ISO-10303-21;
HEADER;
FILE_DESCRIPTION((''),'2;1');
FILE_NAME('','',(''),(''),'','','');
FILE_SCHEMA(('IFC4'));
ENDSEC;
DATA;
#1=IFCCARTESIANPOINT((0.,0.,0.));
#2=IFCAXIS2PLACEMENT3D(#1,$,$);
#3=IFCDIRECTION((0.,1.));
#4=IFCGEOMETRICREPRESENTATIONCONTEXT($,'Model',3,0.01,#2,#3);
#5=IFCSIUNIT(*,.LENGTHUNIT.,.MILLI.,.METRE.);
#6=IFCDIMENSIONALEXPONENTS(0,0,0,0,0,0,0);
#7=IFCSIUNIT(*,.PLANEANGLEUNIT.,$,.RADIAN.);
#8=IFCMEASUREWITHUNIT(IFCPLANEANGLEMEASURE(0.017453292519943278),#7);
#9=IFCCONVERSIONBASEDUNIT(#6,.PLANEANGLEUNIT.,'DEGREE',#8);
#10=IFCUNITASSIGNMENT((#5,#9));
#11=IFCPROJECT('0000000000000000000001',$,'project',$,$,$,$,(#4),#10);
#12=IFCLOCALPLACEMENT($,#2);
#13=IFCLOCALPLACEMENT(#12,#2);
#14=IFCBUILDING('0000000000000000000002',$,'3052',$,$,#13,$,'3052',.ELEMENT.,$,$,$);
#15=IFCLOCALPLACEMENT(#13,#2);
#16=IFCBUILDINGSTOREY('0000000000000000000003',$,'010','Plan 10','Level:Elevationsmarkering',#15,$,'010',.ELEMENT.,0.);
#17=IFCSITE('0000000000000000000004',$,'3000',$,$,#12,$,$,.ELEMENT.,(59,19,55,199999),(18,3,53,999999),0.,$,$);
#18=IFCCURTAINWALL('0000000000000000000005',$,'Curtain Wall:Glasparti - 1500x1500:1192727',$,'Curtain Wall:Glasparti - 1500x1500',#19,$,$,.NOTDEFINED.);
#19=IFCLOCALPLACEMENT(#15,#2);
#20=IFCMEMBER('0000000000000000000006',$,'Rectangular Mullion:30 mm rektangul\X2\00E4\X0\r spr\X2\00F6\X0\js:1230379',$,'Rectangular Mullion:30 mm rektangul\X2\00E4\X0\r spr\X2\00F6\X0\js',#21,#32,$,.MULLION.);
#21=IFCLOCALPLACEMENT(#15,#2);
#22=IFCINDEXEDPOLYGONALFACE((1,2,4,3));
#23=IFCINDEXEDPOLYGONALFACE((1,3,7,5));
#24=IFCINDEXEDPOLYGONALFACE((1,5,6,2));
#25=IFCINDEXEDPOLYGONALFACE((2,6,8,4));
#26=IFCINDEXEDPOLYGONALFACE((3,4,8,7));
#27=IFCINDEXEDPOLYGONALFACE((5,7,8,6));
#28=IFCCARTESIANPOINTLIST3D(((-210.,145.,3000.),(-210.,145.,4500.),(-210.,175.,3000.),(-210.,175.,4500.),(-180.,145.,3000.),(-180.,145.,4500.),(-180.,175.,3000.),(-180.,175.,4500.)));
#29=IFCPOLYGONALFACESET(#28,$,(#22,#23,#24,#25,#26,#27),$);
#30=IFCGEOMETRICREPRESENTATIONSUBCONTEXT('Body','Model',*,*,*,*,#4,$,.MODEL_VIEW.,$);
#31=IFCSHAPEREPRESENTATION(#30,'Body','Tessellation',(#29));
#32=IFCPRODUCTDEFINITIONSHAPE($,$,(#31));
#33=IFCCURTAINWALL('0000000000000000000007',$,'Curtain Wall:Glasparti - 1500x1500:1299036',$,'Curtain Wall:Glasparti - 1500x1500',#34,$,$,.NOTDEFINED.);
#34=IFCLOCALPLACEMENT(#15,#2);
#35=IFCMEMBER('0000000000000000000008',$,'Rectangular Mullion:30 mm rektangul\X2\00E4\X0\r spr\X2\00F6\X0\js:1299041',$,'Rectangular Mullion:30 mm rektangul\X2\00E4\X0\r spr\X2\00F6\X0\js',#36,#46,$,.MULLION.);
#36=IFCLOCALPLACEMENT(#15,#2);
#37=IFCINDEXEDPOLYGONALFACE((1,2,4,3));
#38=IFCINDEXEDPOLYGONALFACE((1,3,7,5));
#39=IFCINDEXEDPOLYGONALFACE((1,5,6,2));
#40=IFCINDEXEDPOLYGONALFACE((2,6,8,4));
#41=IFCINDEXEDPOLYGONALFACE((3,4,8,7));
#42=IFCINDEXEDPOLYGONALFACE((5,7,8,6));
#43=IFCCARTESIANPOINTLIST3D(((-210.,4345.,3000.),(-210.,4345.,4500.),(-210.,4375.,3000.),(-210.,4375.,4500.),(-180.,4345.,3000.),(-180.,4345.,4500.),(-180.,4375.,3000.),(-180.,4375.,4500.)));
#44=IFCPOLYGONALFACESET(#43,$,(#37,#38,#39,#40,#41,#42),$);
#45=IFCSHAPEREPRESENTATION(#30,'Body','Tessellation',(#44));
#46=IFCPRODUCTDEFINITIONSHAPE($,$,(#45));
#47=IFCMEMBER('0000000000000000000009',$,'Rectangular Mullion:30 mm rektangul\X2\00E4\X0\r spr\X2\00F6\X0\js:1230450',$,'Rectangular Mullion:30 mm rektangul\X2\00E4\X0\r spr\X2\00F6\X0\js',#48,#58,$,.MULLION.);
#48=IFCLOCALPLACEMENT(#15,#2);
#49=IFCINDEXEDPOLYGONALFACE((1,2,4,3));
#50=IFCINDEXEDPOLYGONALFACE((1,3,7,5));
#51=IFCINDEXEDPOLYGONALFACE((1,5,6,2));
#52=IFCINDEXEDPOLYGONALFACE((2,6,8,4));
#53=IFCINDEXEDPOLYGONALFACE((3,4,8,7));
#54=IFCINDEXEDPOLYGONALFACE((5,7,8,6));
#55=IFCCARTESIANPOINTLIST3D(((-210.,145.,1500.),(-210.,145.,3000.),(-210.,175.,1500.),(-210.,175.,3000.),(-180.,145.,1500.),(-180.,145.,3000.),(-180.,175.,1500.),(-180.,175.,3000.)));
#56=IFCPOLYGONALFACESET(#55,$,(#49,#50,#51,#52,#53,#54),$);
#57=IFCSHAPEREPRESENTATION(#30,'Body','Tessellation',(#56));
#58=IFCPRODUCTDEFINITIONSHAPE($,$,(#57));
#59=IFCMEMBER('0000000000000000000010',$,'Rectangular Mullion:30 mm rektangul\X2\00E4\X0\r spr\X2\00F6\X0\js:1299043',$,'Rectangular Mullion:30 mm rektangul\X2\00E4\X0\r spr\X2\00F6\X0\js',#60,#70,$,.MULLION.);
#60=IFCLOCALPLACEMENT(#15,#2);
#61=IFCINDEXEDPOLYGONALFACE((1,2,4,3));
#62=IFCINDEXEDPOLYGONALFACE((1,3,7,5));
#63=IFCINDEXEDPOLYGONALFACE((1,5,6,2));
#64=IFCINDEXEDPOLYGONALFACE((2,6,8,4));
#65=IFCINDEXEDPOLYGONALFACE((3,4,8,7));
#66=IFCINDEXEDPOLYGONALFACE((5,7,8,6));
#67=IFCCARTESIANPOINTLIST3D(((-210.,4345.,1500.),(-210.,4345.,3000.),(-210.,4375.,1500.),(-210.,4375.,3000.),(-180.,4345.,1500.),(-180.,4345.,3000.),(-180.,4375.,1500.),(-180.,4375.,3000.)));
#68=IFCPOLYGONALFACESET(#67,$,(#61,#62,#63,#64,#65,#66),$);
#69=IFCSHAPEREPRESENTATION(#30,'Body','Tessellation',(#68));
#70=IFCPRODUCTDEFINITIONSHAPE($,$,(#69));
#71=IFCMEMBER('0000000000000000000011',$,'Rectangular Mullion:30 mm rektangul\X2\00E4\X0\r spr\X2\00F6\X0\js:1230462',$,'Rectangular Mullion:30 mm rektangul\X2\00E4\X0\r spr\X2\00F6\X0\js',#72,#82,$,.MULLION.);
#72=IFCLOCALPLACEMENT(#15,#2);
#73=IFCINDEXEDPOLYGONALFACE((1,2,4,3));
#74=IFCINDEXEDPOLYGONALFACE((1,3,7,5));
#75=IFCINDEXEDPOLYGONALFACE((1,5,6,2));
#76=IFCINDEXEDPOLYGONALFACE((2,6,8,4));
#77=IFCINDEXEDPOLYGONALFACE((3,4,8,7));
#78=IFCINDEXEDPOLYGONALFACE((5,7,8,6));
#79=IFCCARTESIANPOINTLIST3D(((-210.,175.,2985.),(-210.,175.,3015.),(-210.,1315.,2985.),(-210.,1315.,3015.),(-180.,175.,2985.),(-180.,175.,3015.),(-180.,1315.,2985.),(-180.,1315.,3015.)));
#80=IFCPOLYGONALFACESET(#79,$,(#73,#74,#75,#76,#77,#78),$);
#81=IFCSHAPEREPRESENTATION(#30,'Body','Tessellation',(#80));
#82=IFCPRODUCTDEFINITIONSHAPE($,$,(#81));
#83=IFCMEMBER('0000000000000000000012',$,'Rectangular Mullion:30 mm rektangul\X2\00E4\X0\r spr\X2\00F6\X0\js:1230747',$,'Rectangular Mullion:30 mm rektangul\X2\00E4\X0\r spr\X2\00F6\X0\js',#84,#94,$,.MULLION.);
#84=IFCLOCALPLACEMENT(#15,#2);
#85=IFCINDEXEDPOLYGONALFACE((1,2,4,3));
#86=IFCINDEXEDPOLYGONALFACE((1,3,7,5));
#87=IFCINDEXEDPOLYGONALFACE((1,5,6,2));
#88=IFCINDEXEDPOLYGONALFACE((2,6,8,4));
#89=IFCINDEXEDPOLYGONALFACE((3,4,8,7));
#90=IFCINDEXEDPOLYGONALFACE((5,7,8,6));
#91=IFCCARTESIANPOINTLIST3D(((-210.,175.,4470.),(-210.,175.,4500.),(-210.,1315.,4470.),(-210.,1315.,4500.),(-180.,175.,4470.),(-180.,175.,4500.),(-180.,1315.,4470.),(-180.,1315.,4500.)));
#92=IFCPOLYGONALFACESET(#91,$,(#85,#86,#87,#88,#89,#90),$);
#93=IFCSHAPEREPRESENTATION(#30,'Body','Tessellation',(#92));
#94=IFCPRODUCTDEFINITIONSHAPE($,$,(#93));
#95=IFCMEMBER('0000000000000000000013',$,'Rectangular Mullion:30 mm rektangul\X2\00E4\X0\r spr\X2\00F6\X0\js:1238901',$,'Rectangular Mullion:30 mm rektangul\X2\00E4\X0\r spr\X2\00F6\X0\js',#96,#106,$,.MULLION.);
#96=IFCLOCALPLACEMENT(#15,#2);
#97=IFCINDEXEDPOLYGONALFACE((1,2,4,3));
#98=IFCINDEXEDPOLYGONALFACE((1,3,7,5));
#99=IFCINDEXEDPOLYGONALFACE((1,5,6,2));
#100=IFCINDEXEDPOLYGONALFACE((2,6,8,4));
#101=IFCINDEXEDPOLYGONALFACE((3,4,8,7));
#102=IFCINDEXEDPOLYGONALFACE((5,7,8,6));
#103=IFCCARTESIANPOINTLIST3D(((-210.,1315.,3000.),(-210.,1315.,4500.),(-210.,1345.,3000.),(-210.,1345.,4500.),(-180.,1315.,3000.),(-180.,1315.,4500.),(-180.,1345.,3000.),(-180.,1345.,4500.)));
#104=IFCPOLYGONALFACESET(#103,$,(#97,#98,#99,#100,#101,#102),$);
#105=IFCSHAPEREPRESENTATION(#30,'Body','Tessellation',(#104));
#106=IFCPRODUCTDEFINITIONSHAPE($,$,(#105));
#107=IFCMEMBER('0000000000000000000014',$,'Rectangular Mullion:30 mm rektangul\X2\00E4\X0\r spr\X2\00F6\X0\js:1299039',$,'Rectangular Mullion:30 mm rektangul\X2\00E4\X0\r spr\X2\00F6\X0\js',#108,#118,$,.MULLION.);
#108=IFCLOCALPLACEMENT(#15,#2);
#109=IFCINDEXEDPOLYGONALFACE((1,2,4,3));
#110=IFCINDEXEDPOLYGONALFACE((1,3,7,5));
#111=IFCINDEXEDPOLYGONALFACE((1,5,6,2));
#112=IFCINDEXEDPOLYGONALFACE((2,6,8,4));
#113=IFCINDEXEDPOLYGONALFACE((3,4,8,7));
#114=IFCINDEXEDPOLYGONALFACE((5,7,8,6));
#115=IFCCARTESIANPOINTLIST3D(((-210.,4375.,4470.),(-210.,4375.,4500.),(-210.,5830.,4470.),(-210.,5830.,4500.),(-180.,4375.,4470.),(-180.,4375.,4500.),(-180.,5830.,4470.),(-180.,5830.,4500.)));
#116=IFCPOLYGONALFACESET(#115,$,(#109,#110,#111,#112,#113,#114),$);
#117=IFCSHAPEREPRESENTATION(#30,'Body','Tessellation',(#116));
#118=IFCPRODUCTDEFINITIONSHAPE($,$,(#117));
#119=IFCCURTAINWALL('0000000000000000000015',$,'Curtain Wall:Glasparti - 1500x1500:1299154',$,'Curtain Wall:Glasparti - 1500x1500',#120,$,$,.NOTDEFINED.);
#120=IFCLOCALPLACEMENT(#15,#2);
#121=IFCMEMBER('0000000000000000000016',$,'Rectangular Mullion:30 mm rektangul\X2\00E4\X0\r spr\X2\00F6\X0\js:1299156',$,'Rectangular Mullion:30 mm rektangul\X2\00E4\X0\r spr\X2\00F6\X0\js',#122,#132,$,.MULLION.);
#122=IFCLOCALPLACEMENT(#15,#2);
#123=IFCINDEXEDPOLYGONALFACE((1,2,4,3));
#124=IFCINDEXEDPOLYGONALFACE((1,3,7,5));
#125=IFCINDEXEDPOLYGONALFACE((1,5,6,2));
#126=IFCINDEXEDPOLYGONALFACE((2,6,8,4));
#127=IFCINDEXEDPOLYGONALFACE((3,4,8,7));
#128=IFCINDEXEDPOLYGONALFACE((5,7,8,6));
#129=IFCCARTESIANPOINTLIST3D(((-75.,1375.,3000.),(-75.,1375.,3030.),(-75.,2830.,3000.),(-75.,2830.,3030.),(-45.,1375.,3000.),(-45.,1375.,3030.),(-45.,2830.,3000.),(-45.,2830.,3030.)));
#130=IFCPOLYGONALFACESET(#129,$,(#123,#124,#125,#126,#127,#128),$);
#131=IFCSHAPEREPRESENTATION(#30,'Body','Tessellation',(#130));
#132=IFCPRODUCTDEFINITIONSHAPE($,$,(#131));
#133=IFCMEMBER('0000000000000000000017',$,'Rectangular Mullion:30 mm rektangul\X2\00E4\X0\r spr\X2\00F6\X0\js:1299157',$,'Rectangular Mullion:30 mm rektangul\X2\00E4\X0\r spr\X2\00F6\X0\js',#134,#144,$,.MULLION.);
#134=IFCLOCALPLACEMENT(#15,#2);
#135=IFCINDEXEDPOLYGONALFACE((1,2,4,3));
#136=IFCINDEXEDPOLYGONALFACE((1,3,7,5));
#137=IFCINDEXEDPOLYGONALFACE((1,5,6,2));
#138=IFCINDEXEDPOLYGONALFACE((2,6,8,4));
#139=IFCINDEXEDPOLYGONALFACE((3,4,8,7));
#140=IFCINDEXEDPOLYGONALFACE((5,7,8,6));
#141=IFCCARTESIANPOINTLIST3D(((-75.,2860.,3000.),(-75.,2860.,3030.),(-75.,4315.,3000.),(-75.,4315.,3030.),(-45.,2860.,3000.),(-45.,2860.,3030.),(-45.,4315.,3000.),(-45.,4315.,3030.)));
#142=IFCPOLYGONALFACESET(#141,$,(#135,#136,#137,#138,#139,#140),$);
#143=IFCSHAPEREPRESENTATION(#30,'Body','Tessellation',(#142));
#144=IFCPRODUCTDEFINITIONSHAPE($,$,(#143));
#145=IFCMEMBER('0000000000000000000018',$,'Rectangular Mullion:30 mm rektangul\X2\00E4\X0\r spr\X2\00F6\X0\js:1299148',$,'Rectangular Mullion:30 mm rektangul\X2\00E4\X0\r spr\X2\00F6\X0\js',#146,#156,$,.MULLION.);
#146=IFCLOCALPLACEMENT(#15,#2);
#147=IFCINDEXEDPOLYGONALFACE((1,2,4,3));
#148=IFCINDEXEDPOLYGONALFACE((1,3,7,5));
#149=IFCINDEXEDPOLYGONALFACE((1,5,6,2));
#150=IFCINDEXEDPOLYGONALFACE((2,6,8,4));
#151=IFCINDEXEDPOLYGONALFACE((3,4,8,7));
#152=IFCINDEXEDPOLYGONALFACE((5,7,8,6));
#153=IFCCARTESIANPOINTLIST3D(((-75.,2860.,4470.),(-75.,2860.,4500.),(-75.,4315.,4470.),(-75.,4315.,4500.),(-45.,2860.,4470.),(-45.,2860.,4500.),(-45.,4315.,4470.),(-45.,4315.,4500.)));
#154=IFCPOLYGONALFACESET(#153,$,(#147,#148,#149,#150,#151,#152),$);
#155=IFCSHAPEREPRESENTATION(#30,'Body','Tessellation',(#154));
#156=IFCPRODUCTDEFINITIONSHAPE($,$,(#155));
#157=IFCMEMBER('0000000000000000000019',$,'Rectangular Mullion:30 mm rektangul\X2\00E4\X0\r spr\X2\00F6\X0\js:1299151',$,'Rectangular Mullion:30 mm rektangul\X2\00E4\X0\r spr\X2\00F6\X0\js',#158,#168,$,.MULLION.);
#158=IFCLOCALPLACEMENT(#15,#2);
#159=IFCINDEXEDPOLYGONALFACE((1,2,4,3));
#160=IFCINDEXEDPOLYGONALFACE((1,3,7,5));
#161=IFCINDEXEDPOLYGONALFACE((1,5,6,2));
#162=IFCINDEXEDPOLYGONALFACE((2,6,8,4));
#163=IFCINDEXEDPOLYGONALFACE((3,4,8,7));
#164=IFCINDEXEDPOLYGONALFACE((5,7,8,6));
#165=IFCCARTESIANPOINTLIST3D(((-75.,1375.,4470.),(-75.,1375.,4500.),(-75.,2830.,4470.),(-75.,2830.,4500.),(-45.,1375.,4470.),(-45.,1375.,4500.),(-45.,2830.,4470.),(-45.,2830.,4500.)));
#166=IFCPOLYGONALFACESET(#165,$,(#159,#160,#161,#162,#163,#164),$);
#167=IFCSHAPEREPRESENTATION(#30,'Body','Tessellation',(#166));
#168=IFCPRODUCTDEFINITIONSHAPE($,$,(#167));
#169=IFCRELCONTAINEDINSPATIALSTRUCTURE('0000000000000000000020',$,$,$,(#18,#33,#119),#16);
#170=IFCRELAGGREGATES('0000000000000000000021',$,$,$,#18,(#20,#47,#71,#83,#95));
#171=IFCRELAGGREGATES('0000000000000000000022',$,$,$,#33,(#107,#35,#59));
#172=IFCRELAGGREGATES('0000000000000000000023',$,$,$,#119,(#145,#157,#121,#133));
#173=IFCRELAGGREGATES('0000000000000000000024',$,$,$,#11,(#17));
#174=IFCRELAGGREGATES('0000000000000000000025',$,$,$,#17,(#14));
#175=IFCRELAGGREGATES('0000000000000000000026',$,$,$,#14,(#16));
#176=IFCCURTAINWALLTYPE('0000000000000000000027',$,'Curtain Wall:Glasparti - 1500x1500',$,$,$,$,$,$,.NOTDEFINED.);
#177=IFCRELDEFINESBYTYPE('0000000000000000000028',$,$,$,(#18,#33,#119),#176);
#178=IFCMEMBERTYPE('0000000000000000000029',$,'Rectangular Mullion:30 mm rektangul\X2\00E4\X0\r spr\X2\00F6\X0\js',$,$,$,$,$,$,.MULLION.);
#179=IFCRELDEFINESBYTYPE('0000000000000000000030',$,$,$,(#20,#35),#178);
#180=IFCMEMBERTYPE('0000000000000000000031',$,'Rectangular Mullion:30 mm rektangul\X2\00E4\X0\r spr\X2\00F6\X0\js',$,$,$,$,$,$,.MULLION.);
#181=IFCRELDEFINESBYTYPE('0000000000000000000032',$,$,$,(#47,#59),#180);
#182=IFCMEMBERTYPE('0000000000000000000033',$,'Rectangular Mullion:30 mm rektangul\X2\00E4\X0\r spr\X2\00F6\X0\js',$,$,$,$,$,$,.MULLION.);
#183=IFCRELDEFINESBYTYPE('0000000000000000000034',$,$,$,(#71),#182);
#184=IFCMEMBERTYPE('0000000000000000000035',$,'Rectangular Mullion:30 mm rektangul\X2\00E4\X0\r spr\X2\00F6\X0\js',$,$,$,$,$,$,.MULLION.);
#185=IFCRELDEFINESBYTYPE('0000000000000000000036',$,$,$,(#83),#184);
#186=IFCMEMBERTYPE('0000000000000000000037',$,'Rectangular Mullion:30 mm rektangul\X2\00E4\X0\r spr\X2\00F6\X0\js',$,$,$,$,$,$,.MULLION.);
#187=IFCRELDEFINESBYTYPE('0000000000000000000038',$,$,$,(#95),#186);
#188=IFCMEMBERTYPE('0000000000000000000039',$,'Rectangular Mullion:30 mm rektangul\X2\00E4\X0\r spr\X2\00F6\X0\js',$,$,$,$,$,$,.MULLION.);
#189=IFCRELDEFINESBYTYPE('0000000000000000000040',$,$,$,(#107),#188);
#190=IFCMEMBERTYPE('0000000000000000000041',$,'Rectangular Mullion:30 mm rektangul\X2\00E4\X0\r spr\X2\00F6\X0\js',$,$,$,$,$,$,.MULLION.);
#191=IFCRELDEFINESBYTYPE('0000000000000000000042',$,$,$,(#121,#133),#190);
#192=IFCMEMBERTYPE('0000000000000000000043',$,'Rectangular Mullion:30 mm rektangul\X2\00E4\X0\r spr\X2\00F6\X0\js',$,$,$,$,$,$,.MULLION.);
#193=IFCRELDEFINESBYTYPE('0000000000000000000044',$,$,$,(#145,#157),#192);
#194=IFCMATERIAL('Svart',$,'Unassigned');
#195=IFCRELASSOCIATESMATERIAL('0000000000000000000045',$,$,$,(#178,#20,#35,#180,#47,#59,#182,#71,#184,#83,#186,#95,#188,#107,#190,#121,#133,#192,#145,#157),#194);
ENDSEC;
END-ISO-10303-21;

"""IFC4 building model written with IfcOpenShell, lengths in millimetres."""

from ifc_helpers import new_model, entity, si_unit, converted_unit, direction, frame, origin, place, context, subcontext, project, spatial, indexed_curve, outline, extrude, source, transform, mapped, material, type_object, type_shapes, element, aggregate, save


model = new_model("IFC4")

# Units and contexts
model_context = context("Model", 3, precision=0.01, world=origin(), true_north=direction((0.0, 1.0)))
body_context = subcontext(model_context, "Body", "Model", "MODEL_VIEW")
ifc_project = project(units=[si_unit("LENGTHUNIT", "METRE", prefix="MILLI"), converted_unit("PLANEANGLEUNIT", "DEGREE", entity("IfcPlaneAngleMeasure", 0.017453292519943278), si_unit("PLANEANGLEUNIT", "RADIAN"), dimensions=[0, 0, 0, 0, 0, 0, 0])], contexts=[model_context])

# Site, building, storey
site_placement = place(None, origin())
site = spatial("IfcSite", under=ifc_project, at=site_placement, Name="3000", CompositionType="ELEMENT", RefLatitude=(59, 19, 55, 199999), RefLongitude=(18, 3, 53, 999999), RefElevation=0.0)
building_placement = place(site_placement, origin())
building = spatial("IfcBuilding", under=site, at=building_placement, Name="3052", LongName="3052", CompositionType="ELEMENT")
storey_placement = place(building_placement, origin())
storey = spatial("IfcBuildingStorey", under=building, at=storey_placement, Name="010", Description="Plan 10", ObjectType="Level:Elevationsmarkering", LongName="010", CompositionType="ELEMENT", Elevation=0.0)

# Curtain walls, members
curtain_wall_type = type_object("IfcCurtainWallType", Name="Curtain Wall:Glasparti - 1500x1500", PredefinedType="NOTDEFINED")
curtain_wall_1_placement = place(storey_placement, origin())
curtain_wall_1 = element("IfcCurtainWall", 1, at=curtain_wall_1_placement, inside=storey, type_object=curtain_wall_type, Name="Curtain Wall:Glasparti - 1500x1500:1192727", ObjectType="Curtain Wall:Glasparti - 1500x1500", PredefinedType="NOTDEFINED")
ifc_material_1 = material(Name="Svart", Category="Unassigned")
member_type_1 = type_object("IfcMemberType", Name="Rectangular Mullion:30 mm rektangulär spröjs", PredefinedType="MULLION", material=ifc_material_1)
shared_shape_1 = source(origin(), body_context, "Body", "SweptSolid", [
    extrude(outline(indexed_curve([(-15.0, -15.0), (15.0, -15.0), (15.0, 15.0), (-15.0, 15.0), (-15.0, -15.0)], self_intersect=False)), frame((-15.0, 0.0, -1500.0), z_axis=(0.0, 0.0, 1.0), x_axis=(-1.0, 0.0, 0.0)), (0.0, 0.0, 1.0), 1500.0),
])
type_shapes(member_type_1, [shared_shape_1])
member_1_placement = place(curtain_wall_1_placement, frame((-195.0, 145.0, 4500.0), z_axis=(0.0, 0.0, 1.0), x_axis=(0.0, -1.0, 0.0)))
member_1 = element("IfcMember", 2, at=member_1_placement, type_object=member_type_1, material=ifc_material_1, Name="Rectangular Mullion:30 mm rektangulär spröjs:1230379", ObjectType="Rectangular Mullion:30 mm rektangulär spröjs", PredefinedType="MULLION", context=body_context, shape_type="MappedRepresentation", body=[
    mapped(shared_shape_1, transform((0.0, 0.0, 0.0), scale=1.0)),
])
curtain_wall_2_placement = place(storey_placement, origin())
curtain_wall_2 = element("IfcCurtainWall", 3, at=curtain_wall_2_placement, inside=storey, type_object=curtain_wall_type, Name="Curtain Wall:Glasparti - 1500x1500:1299036", ObjectType="Curtain Wall:Glasparti - 1500x1500", PredefinedType="NOTDEFINED")
member_2_placement = place(curtain_wall_2_placement, frame((-195.0, 4345.0, 4500.0), z_axis=(0.0, 0.0, 1.0), x_axis=(0.0, -1.0, 0.0)))
member_2 = element("IfcMember", 4, at=member_2_placement, type_object=member_type_1, material=ifc_material_1, Name="Rectangular Mullion:30 mm rektangulär spröjs:1299041", ObjectType="Rectangular Mullion:30 mm rektangulär spröjs", PredefinedType="MULLION", context=body_context, shape_type="MappedRepresentation", body=[
    mapped(shared_shape_1, transform((0.0, 0.0, 0.0), scale=1.0)),
])

# Members
member_type_2 = type_object("IfcMemberType", Name="Rectangular Mullion:30 mm rektangulär spröjs", PredefinedType="MULLION", material=ifc_material_1)
shared_shape_2 = source(origin(), body_context, "Body", "SweptSolid", [
    extrude(outline(indexed_curve([(-15.0, -15.0), (15.0, -15.0), (15.0, 15.0), (-15.0, 15.0), (-15.0, -15.0)], self_intersect=False)), frame((-15.0, 0.0, -1500.0), z_axis=(0.0, 0.0, 1.0), x_axis=(-1.0, 0.0, 0.0)), (0.0, 0.0, 1.0), 1500.0),
])
type_shapes(member_type_2, [shared_shape_2])
member_3_placement = place(curtain_wall_1_placement, frame((-195.0, 145.0, 3000.0), z_axis=(0.0, 0.0, 1.0), x_axis=(0.0, -1.0, 0.0)))
member_3 = element("IfcMember", 5, at=member_3_placement, type_object=member_type_2, material=ifc_material_1, Name="Rectangular Mullion:30 mm rektangulär spröjs:1230450", ObjectType="Rectangular Mullion:30 mm rektangulär spröjs", PredefinedType="MULLION", context=body_context, shape_type="MappedRepresentation", body=[
    mapped(shared_shape_2, transform((0.0, 0.0, 0.0), scale=1.0)),
])
member_4_placement = place(curtain_wall_2_placement, frame((-195.0, 4345.0, 3000.0), z_axis=(0.0, 0.0, 1.0), x_axis=(0.0, -1.0, 0.0)))
member_4 = element("IfcMember", 6, at=member_4_placement, type_object=member_type_2, material=ifc_material_1, Name="Rectangular Mullion:30 mm rektangulär spröjs:1299043", ObjectType="Rectangular Mullion:30 mm rektangulär spröjs", PredefinedType="MULLION", context=body_context, shape_type="MappedRepresentation", body=[
    mapped(shared_shape_2, transform((0.0, 0.0, 0.0), scale=1.0)),
])
member_type_3 = type_object("IfcMemberType", Name="Rectangular Mullion:30 mm rektangulär spröjs", PredefinedType="MULLION", material=ifc_material_1)
shared_shape_3 = source(origin(), body_context, "Body", "SweptSolid", [
    extrude(outline(indexed_curve([(-15.0, -15.0), (15.0, -15.0), (15.0, 15.0), (-15.0, 15.0), (-15.0, -15.0)], self_intersect=False)), frame((0.0, 0.0, -1140.0), z_axis=(0.0, 0.0, 1.0), x_axis=(-1.0, 0.0, 0.0)), (0.0, 0.0, 1.0), 1140.0),
])
type_shapes(member_type_3, [shared_shape_3])
member_5_placement = place(curtain_wall_1_placement, frame((-195.0, 1315.0, 3000.0), z_axis=(0.0, 1.0, 0.0), x_axis=(0.0, 0.0, 1.0)))
member_5 = element("IfcMember", 7, at=member_5_placement, type_object=member_type_3, material=ifc_material_1, Name="Rectangular Mullion:30 mm rektangulär spröjs:1230462", ObjectType="Rectangular Mullion:30 mm rektangulär spröjs", PredefinedType="MULLION", context=body_context, shape_type="MappedRepresentation", body=[
    mapped(shared_shape_3, transform((0.0, 0.0, 0.0), scale=1.0)),
])
member_type_4 = type_object("IfcMemberType", Name="Rectangular Mullion:30 mm rektangulär spröjs", PredefinedType="MULLION", material=ifc_material_1)
shared_shape_4 = source(origin(), body_context, "Body", "SweptSolid", [
    extrude(outline(indexed_curve([(-15.0, -15.0), (15.0, -15.0), (15.0, 15.0), (-15.0, 15.0), (-15.0, -15.0)], self_intersect=False)), frame((-15.0, 0.0, -1140.0), z_axis=(0.0, 0.0, 1.0), x_axis=(-1.0, 0.0, 0.0)), (0.0, 0.0, 1.0), 1140.0),
])
type_shapes(member_type_4, [shared_shape_4])
member_6_placement = place(curtain_wall_1_placement, frame((-195.0, 1315.0, 4500.0), z_axis=(0.0, 1.0, 0.0), x_axis=(0.0, 0.0, 1.0)))
member_6 = element("IfcMember", 8, at=member_6_placement, type_object=member_type_4, material=ifc_material_1, Name="Rectangular Mullion:30 mm rektangulär spröjs:1230747", ObjectType="Rectangular Mullion:30 mm rektangulär spröjs", PredefinedType="MULLION", context=body_context, shape_type="MappedRepresentation", body=[
    mapped(shared_shape_4, transform((0.0, 0.0, 0.0), scale=1.0)),
])
member_type_5 = type_object("IfcMemberType", Name="Rectangular Mullion:30 mm rektangulär spröjs", PredefinedType="MULLION", material=ifc_material_1)
shared_shape_5 = source(origin(), body_context, "Body", "SweptSolid", [
    extrude(outline(indexed_curve([(-15.0, -15.0), (15.0, -15.0), (15.0, 15.0), (-15.0, 15.0), (-15.0, -15.0)], self_intersect=False)), frame((-15.0, 0.0, -1500.0), z_axis=(0.0, 0.0, 1.0), x_axis=(-1.0, 0.0, 0.0)), (0.0, 0.0, 1.0), 1500.0),
])
type_shapes(member_type_5, [shared_shape_5])
member_7_placement = place(curtain_wall_1_placement, frame((-195.0, 1345.0, 3000.0), z_axis=(0.0, 0.0, -1.0), x_axis=(0.0, 1.0, 0.0)))
member_7 = element("IfcMember", 9, at=member_7_placement, type_object=member_type_5, material=ifc_material_1, Name="Rectangular Mullion:30 mm rektangulär spröjs:1238901", ObjectType="Rectangular Mullion:30 mm rektangulär spröjs", PredefinedType="MULLION", context=body_context, shape_type="MappedRepresentation", body=[
    mapped(shared_shape_5, transform((0.0, 0.0, 0.0), scale=1.0)),
])
member_type_6 = type_object("IfcMemberType", Name="Rectangular Mullion:30 mm rektangulär spröjs", PredefinedType="MULLION", material=ifc_material_1)
shared_shape_6 = source(origin(), body_context, "Body", "SweptSolid", [
    extrude(outline(indexed_curve([(-15.0, -15.0), (15.0, -15.0), (15.0, 15.0), (-15.0, 15.0), (-15.0, -15.0)], self_intersect=False)), frame((-15.0, 0.0, -1455.0), z_axis=(0.0, 0.0, 1.0), x_axis=(-1.0, 0.0, 0.0)), (0.0, 0.0, 1.0), 1455.0),
])
type_shapes(member_type_6, [shared_shape_6])
member_8_placement = place(curtain_wall_2_placement, frame((-195.0, 5830.0, 4500.0), z_axis=(0.0, 1.0, 0.0), x_axis=(0.0, 0.0, 1.0)))
member_8 = element("IfcMember", 10, at=member_8_placement, type_object=member_type_6, material=ifc_material_1, Name="Rectangular Mullion:30 mm rektangulär spröjs:1299039", ObjectType="Rectangular Mullion:30 mm rektangulär spröjs", PredefinedType="MULLION", context=body_context, shape_type="MappedRepresentation", body=[
    mapped(shared_shape_6, transform((0.0, 0.0, 0.0), scale=1.0)),
])

# Curtain wall, members
curtain_wall_3_placement = place(storey_placement, origin())
curtain_wall_3 = element("IfcCurtainWall", 11, at=curtain_wall_3_placement, inside=storey, type_object=curtain_wall_type, Name="Curtain Wall:Glasparti - 1500x1500:1299154", ObjectType="Curtain Wall:Glasparti - 1500x1500", PredefinedType="NOTDEFINED")
member_type_7 = type_object("IfcMemberType", Name="Rectangular Mullion:30 mm rektangulär spröjs", PredefinedType="MULLION", material=ifc_material_1)
shared_shape_7 = source(origin(), body_context, "Body", "SweptSolid", [
    extrude(outline(indexed_curve([(-15.0, -15.0), (15.0, -15.0), (15.0, 15.0), (-15.0, 15.0), (-15.0, -15.0)], self_intersect=False)), frame((-15.0, 0.0, -1455.0), z_axis=(0.0, 0.0, 1.0), x_axis=(-1.0, 0.0, 0.0)), (0.0, 0.0, 1.0), 1455.0),
])
type_shapes(member_type_7, [shared_shape_7])
member_9_placement = place(curtain_wall_3_placement, frame((-60.0, 1375.0, 3000.0), z_axis=(0.0, -1.0, 0.0), x_axis=(0.0, 0.0, -1.0)))
member_9 = element("IfcMember", 12, at=member_9_placement, type_object=member_type_7, material=ifc_material_1, Name="Rectangular Mullion:30 mm rektangulär spröjs:1299156", ObjectType="Rectangular Mullion:30 mm rektangulär spröjs", PredefinedType="MULLION", context=body_context, shape_type="MappedRepresentation", body=[
    mapped(shared_shape_7, transform((0.0, 0.0, 0.0), scale=1.0)),
])
member_10_placement = place(curtain_wall_3_placement, frame((-60.0, 2860.0, 3000.0), z_axis=(0.0, -1.0, 0.0), x_axis=(0.0, 0.0, -1.0)))
member_10 = element("IfcMember", 13, at=member_10_placement, type_object=member_type_7, material=ifc_material_1, Name="Rectangular Mullion:30 mm rektangulär spröjs:1299157", ObjectType="Rectangular Mullion:30 mm rektangulär spröjs", PredefinedType="MULLION", context=body_context, shape_type="MappedRepresentation", body=[
    mapped(shared_shape_7, transform((0.0, 0.0, 0.0), scale=1.0)),
])
member_type_8 = type_object("IfcMemberType", Name="Rectangular Mullion:30 mm rektangulär spröjs", PredefinedType="MULLION", material=ifc_material_1)
shared_shape_8 = source(origin(), body_context, "Body", "SweptSolid", [
    extrude(outline(indexed_curve([(-15.0, -15.0), (15.0, -15.0), (15.0, 15.0), (-15.0, 15.0), (-15.0, -15.0)], self_intersect=False)), frame((-15.0, 0.0, -1455.0), z_axis=(0.0, 0.0, 1.0), x_axis=(-1.0, 0.0, 0.0)), (0.0, 0.0, 1.0), 1455.0),
])
type_shapes(member_type_8, [shared_shape_8])
member_11_placement = place(curtain_wall_3_placement, frame((-60.0, 4315.0, 4500.0), z_axis=(0.0, 1.0, 0.0), x_axis=(0.0, 0.0, 1.0)))
member_11 = element("IfcMember", 14, at=member_11_placement, type_object=member_type_8, material=ifc_material_1, Name="Rectangular Mullion:30 mm rektangulär spröjs:1299148", ObjectType="Rectangular Mullion:30 mm rektangulär spröjs", PredefinedType="MULLION", context=body_context, shape_type="MappedRepresentation", body=[
    mapped(shared_shape_8, transform((0.0, 0.0, 0.0), scale=1.0)),
])
member_12_placement = place(curtain_wall_3_placement, frame((-60.0, 2830.0, 4500.0), z_axis=(0.0, 1.0, 0.0), x_axis=(0.0, 0.0, 1.0)))
member_12 = element("IfcMember", 15, at=member_12_placement, type_object=member_type_8, material=ifc_material_1, Name="Rectangular Mullion:30 mm rektangulär spröjs:1299151", ObjectType="Rectangular Mullion:30 mm rektangulär spröjs", PredefinedType="MULLION", context=body_context, shape_type="MappedRepresentation", body=[
    mapped(shared_shape_8, transform((0.0, 0.0, 0.0), scale=1.0)),
])

aggregate(curtain_wall_1, [member_1, member_3, member_5, member_6, member_7])
aggregate(curtain_wall_2, [member_8, member_2, member_4])
aggregate(curtain_wall_3, [member_11, member_12, member_9, member_10])

save(model, "model.ifc")
